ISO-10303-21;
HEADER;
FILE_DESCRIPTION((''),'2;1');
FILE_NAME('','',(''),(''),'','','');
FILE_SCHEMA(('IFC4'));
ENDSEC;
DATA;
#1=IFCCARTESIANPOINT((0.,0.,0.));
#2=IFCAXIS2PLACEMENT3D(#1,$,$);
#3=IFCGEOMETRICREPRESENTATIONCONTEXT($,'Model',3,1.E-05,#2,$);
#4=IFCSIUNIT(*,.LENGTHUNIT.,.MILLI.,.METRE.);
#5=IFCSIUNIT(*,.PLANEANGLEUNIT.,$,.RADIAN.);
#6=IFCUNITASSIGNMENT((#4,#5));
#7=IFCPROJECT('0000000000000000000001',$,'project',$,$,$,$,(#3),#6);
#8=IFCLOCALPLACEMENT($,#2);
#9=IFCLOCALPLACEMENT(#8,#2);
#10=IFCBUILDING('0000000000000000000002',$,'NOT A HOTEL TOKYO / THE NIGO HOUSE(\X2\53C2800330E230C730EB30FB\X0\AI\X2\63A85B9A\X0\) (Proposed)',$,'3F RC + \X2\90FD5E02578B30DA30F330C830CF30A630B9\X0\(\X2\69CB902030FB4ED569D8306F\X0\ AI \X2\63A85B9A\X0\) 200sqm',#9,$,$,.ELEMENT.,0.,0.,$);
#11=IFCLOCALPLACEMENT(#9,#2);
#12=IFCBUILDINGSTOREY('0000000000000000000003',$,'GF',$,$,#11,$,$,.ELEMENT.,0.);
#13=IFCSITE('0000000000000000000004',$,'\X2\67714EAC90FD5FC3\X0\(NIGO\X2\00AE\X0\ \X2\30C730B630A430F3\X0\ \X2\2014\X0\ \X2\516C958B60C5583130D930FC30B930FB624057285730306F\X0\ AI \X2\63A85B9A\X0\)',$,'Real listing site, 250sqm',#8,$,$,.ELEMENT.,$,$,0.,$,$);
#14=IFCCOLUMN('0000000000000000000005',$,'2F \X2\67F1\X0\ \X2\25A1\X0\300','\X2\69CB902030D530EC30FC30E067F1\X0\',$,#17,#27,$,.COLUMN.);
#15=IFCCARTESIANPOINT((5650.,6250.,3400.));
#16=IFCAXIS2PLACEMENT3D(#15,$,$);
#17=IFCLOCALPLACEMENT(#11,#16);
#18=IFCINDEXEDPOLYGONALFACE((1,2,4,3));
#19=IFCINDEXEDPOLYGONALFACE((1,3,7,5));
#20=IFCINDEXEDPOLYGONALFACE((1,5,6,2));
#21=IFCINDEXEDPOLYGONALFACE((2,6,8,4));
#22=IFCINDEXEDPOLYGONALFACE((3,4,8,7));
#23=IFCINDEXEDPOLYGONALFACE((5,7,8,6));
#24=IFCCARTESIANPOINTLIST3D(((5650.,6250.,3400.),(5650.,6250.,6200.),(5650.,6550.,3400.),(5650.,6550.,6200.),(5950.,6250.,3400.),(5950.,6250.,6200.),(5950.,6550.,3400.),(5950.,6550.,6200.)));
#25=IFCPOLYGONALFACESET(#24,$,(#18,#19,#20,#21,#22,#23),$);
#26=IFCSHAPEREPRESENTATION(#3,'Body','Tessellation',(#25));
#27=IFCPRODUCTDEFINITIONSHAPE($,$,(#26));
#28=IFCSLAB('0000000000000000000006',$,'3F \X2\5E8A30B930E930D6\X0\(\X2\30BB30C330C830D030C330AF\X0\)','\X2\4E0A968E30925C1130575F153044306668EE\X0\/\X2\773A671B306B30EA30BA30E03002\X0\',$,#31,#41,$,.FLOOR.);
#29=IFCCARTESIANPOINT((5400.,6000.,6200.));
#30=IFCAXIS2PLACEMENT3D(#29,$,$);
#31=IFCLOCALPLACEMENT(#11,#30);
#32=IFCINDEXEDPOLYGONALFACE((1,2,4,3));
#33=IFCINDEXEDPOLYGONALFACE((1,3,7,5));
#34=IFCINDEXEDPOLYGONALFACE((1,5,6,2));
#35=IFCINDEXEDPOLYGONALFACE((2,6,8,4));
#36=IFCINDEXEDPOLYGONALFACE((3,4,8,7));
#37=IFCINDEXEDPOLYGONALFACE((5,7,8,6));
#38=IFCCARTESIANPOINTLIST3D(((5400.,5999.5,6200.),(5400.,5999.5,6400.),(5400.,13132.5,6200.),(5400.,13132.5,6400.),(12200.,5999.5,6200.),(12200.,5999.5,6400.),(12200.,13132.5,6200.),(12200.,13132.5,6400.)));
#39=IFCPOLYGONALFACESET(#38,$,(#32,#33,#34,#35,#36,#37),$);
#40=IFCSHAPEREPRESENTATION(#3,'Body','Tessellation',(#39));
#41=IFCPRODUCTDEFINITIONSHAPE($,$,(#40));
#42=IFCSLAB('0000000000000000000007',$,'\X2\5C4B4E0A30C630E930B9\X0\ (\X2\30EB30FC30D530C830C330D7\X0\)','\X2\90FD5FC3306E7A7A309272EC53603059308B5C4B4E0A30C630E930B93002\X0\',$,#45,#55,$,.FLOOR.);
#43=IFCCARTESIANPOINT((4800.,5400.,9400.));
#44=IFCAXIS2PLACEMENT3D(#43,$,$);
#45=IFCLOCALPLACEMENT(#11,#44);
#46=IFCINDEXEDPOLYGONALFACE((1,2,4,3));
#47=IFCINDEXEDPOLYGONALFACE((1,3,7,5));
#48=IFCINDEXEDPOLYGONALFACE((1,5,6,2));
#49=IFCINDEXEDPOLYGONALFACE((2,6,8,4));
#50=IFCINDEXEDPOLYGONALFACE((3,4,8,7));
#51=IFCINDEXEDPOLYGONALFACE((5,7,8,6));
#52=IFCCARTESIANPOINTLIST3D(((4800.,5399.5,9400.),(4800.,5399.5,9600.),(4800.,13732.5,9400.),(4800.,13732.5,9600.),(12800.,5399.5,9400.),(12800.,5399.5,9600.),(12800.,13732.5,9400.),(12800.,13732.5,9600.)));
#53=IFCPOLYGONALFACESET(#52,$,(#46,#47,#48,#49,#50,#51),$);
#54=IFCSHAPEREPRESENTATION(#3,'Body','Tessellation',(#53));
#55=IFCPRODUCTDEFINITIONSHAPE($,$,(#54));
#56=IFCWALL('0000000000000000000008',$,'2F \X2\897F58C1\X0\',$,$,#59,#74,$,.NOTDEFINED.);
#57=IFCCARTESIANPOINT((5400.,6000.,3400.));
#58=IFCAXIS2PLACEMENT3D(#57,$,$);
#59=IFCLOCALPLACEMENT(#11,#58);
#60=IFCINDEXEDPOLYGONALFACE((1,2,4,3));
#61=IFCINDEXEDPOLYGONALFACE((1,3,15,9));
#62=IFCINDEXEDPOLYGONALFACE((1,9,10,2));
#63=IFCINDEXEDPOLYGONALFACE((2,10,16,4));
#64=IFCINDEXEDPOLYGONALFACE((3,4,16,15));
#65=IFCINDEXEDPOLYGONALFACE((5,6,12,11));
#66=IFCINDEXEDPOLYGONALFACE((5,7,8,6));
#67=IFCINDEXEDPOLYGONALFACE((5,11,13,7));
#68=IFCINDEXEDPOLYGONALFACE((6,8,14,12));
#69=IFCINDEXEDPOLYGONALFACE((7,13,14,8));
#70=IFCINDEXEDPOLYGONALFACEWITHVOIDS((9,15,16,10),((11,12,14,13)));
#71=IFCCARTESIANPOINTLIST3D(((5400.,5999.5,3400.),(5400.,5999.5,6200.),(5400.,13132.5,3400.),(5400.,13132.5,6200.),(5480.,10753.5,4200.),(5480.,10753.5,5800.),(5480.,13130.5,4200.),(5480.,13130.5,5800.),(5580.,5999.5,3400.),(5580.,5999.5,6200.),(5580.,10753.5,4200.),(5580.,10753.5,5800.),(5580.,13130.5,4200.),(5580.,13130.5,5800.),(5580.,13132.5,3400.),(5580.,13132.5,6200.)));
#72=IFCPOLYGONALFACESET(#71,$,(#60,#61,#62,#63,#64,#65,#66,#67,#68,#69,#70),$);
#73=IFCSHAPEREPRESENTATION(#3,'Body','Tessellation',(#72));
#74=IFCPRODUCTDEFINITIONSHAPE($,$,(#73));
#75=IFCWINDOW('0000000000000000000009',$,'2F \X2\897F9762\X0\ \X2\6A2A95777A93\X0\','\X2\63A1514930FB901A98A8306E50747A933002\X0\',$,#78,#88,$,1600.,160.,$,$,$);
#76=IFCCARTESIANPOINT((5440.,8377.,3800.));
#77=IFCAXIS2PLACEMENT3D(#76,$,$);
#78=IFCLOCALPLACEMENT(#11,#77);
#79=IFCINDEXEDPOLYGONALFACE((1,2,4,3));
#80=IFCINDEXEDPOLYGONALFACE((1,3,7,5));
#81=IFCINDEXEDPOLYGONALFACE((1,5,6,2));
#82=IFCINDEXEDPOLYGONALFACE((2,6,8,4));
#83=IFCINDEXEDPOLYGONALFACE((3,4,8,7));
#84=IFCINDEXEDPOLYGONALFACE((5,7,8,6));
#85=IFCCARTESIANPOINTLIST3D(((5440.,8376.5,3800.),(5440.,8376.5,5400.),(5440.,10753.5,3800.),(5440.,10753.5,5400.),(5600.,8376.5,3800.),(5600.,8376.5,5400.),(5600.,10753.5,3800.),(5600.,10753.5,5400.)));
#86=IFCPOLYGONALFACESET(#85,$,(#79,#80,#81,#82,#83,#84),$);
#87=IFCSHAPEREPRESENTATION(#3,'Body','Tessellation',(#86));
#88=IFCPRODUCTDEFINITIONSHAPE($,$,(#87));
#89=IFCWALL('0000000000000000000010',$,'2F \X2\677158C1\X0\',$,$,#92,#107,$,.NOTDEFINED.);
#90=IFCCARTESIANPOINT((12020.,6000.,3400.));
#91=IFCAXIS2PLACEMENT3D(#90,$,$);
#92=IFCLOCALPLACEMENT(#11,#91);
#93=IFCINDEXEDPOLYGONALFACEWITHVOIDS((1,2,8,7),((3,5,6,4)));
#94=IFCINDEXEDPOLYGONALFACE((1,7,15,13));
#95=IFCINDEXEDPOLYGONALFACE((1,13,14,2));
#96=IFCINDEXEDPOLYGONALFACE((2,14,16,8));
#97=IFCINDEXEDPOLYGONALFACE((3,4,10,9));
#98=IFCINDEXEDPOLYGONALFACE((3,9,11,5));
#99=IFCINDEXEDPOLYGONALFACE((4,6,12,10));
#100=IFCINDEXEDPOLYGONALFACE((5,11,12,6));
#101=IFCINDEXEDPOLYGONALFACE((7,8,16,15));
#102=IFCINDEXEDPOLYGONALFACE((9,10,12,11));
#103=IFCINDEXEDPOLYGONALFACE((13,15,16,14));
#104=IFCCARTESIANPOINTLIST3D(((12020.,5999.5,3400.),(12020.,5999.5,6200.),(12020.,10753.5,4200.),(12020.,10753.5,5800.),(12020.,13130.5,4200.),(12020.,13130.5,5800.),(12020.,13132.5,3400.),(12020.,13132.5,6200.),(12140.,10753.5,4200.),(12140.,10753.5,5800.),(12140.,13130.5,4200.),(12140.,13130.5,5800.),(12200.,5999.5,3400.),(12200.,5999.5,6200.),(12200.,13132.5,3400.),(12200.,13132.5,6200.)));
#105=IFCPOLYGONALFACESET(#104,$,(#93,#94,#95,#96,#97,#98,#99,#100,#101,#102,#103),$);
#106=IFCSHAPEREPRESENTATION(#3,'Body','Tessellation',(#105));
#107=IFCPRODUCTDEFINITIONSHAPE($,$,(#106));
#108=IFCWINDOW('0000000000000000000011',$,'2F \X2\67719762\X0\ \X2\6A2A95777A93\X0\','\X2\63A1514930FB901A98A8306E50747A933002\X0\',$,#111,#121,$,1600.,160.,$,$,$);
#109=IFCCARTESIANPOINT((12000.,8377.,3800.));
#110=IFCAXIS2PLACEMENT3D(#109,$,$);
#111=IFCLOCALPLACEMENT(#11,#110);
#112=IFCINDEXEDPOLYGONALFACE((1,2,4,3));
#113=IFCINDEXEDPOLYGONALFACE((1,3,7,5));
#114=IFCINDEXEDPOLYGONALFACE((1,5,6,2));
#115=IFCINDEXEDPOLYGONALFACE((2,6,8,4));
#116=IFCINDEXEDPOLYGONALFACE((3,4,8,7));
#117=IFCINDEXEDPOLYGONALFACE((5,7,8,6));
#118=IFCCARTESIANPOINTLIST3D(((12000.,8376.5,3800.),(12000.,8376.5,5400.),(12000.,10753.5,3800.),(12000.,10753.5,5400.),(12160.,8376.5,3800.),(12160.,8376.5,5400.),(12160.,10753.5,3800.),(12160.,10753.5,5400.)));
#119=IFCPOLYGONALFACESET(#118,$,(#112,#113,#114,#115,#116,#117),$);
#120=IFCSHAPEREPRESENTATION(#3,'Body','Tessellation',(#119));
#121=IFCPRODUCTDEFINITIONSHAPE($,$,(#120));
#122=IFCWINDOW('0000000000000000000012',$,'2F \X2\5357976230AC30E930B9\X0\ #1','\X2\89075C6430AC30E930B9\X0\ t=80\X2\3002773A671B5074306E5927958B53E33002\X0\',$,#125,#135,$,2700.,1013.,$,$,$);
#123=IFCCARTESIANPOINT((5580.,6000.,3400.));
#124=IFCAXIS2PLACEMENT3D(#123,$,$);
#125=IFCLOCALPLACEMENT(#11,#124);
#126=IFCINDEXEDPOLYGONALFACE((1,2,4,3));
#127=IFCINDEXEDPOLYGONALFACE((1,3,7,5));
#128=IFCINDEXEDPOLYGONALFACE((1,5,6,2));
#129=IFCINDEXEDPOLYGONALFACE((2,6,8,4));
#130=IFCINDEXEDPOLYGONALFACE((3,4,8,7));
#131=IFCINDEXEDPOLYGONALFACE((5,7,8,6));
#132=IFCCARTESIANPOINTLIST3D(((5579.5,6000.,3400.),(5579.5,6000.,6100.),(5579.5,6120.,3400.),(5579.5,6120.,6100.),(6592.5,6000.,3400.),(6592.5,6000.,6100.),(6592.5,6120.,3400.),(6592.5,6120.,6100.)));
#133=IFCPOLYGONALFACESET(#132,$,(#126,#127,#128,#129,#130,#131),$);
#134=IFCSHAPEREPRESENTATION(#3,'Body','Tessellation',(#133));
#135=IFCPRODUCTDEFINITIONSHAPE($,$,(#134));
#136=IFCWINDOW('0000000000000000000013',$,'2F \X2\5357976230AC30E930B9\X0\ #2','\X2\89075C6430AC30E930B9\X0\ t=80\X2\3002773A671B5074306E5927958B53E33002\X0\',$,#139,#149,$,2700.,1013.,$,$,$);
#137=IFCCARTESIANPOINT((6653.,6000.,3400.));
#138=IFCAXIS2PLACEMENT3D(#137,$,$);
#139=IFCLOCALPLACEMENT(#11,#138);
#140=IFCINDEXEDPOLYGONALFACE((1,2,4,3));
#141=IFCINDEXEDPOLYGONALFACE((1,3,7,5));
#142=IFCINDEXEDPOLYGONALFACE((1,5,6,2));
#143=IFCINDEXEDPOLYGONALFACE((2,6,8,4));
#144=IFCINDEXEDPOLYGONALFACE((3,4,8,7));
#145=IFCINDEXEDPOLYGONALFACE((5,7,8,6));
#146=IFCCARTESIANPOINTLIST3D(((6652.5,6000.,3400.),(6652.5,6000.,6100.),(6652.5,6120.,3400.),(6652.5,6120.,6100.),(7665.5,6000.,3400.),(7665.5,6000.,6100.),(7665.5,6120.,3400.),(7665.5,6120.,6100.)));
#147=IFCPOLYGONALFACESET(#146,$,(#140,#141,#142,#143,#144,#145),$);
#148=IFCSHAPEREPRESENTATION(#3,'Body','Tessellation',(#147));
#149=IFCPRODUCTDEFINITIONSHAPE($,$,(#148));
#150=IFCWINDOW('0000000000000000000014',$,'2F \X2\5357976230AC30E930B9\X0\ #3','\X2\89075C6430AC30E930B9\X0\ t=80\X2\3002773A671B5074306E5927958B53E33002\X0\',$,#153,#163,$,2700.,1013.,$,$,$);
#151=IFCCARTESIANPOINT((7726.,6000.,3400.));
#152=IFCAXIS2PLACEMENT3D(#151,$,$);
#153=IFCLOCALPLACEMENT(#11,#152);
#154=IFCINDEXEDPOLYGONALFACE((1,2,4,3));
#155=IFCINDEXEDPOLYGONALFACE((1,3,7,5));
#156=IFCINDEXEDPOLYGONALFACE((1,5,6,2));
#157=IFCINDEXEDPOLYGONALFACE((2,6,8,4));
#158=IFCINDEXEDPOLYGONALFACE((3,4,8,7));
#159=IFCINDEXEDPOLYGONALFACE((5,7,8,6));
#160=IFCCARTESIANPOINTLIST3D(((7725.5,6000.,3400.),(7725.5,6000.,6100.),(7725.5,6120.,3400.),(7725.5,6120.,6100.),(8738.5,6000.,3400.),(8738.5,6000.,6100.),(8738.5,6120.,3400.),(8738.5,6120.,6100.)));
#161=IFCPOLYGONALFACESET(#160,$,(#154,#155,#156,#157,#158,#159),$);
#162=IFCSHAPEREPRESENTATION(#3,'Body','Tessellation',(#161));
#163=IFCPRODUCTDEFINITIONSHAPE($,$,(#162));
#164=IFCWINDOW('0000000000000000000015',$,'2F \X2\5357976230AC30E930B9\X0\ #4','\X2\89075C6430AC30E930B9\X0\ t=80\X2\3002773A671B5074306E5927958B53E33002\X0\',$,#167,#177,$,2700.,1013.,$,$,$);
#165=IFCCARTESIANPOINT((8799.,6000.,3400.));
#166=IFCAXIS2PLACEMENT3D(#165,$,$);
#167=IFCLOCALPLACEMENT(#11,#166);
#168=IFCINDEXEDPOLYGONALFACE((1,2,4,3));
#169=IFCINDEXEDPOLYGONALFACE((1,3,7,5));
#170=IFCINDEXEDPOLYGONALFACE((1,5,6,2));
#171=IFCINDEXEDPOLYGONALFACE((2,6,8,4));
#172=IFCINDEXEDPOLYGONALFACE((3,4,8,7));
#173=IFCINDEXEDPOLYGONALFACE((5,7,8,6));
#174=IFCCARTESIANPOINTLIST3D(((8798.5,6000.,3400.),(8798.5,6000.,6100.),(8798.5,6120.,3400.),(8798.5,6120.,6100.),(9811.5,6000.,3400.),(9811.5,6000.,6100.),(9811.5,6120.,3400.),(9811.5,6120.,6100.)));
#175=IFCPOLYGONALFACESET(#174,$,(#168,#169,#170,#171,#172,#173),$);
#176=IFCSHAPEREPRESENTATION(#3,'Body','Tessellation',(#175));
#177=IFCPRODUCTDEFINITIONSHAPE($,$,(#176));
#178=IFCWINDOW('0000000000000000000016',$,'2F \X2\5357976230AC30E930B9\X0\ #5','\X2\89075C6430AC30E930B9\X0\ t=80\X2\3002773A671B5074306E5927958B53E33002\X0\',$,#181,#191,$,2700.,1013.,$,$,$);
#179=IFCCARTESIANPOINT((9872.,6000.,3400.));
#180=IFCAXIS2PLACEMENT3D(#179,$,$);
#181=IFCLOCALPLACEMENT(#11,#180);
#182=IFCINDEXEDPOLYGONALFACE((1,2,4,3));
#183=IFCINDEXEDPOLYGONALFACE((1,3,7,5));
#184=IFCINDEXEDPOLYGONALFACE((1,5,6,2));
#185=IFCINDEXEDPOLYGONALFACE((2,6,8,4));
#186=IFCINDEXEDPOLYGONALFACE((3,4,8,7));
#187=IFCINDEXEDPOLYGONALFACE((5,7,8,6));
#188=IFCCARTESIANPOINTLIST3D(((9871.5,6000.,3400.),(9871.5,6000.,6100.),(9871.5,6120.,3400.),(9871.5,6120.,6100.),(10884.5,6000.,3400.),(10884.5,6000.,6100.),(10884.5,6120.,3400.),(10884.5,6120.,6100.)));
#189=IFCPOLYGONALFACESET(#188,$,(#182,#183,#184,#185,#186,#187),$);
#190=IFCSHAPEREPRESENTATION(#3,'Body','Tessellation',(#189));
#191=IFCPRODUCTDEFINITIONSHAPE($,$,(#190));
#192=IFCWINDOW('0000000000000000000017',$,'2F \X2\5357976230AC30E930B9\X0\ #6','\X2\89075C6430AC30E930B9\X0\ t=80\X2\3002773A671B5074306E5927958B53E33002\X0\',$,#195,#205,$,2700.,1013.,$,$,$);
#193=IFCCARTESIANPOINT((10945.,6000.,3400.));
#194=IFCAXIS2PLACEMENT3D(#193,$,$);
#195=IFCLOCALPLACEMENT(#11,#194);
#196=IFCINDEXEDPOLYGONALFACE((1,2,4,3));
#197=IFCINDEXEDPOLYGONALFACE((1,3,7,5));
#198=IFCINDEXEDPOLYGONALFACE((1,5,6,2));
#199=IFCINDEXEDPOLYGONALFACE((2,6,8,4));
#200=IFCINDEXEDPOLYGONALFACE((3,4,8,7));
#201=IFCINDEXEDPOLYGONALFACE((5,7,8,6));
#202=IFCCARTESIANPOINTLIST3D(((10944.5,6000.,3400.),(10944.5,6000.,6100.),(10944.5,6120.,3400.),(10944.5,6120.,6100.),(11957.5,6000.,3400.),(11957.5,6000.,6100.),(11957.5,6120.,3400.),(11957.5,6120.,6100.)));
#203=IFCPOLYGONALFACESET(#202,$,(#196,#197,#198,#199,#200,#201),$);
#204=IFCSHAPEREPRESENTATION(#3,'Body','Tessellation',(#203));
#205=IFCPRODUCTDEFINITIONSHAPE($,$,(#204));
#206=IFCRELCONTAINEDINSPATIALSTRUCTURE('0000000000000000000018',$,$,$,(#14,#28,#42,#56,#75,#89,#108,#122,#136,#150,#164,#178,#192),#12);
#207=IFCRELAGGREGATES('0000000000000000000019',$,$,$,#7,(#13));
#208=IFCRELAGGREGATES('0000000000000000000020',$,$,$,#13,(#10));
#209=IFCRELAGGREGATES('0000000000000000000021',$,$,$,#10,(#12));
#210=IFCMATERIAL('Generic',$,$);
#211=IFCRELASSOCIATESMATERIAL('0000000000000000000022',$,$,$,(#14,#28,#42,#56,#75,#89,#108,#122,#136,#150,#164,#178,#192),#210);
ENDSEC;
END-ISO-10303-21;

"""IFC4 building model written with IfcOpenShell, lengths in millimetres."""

from ifc_helpers import new_model, si_unit, frame, frame_2d, origin, place, context, project, spatial, rectangle, extrude, material, element, fill, save


model = new_model("IFC4")

# Units and contexts
model_context = context("Model", 3, precision=1e-05, world=origin())
ifc_project = project(units=[si_unit("LENGTHUNIT", "METRE", prefix="MILLI"), si_unit("PLANEANGLEUNIT", "RADIAN")], contexts=[model_context])

# Site, building, storey
site_placement = place(None, origin())
site = spatial("IfcSite", under=ifc_project, at=site_placement, Name="東京都心(NIGO® デザイン — 公開情報ベース・所在地は AI 推定)", ObjectType="Real listing site, 250sqm", CompositionType="ELEMENT", RefElevation=0.0)
building_placement = place(site_placement, origin())
building = spatial("IfcBuilding", under=site, at=building_placement, Name="NOT A HOTEL TOKYO / THE NIGO HOUSE(参考モデル・AI推定) (Proposed)", ObjectType="3F RC + 都市型ペントハウス(構造・仕様は AI 推定) 200sqm", CompositionType="ELEMENT", ElevationOfRefHeight=0.0, ElevationOfTerrain=0.0)
storey_placement = place(building_placement, origin())
storey = spatial("IfcBuildingStorey", under=building, at=storey_placement, Name="GF", CompositionType="ELEMENT", Elevation=0.0)

# Column
ifc_material_1 = material(Name="Generic")
column_placement = place(storey_placement, frame((5650.0, 6250.0, 3400.0)))
element("IfcColumn", 1, at=column_placement, inside=storey, material=ifc_material_1, Name="2F 柱 □300", Description="構造フレーム柱", PredefinedType="COLUMN", context=model_context, shape_type="SweptSolid", body=[
    extrude(rectangle(XDim=300.0, YDim=300.0, at=frame_2d((150.0, 150.0))), frame((5650.0, 6250.0, 3400.0)), (0.0, 0.0, 1.0), 2800.0),
])

# Slabs
slab_1_placement = place(storey_placement, frame((5400.0, 6000.0, 6200.0)))
element("IfcSlab", 2, at=slab_1_placement, inside=storey, material=ifc_material_1, Name="3F 床スラブ(セットバック)", Description="上階を少し引いて森/眺望にリズム。", PredefinedType="FLOOR", context=model_context, shape_type="SweptSolid", body=[
    extrude(rectangle(XDim=6800.0, YDim=7133.0, at=frame_2d((3400.0, 3566.0))), frame((5400.0, 6000.0, 6200.0)), (0.0, 0.0, 1.0), 200.0),
])
slab_2_placement = place(storey_placement, frame((4800.0, 5400.0, 9400.0)))
element("IfcSlab", 3, at=slab_2_placement, inside=storey, material=ifc_material_1, Name="屋上テラス (ルーフトップ)", Description="都心の空を独占する屋上テラス。", PredefinedType="FLOOR", context=model_context, shape_type="SweptSolid", body=[
    extrude(rectangle(XDim=8000.0, YDim=8333.0, at=frame_2d((4000.0, 4166.0))), frame((4800.0, 5400.0, 9400.0)), (0.0, 0.0, 1.0), 200.0),
])

# Walls, openings, windows
wall_1_placement = place(storey_placement, frame((5400.0, 6000.0, 3400.0)))
wall_1 = element("IfcWall", 4, at=wall_1_placement, inside=storey, material=ifc_material_1, Name="2F 西壁", PredefinedType="NOTDEFINED", context=model_context, shape_type="SweptSolid", body=[
    extrude(rectangle(XDim=180.0, YDim=7133.0, at=frame_2d((90.0, 3566.0))), frame((5400.0, 6000.0, 3400.0)), (0.0, 0.0, 1.0), 2800.0),
])
opening_1_placement = place(storey_placement, frame((5440.0, 8377.0, 3800.0)))
opening_1 = element("IfcOpeningElement", 5, at=opening_1_placement, cuts=wall_1, PredefinedType="NOTDEFINED", context=model_context, shape_type="SweptSolid", body=[
    extrude(rectangle(XDim=160.0, YDim=2377.0, at=frame_2d((80.0, 1188.0))), frame((5440.0, 8377.0, 3800.0)), (0.0, 0.0, 1.0), 1600.0),
])
window_1_placement = place(storey_placement, frame((5440.0, 8377.0, 3800.0)))
window_1 = element("IfcWindow", 6, at=window_1_placement, inside=storey, material=ifc_material_1, Name="2F 西面 横長窓", Description="採光・通風の側窓。", OverallHeight=1600.0, OverallWidth=160.0, context=model_context, shape_type="SweptSolid", body=[
    extrude(rectangle(XDim=160.0, YDim=2377.0, at=frame_2d((80.0, 1188.0))), frame((5440.0, 8377.0, 3800.0)), (0.0, 0.0, 1.0), 1600.0),
])
fill(opening_1, window_1)
wall_2_placement = place(storey_placement, frame((12020.0, 6000.0, 3400.0)))
wall_2 = element("IfcWall", 7, at=wall_2_placement, inside=storey, material=ifc_material_1, Name="2F 東壁", PredefinedType="NOTDEFINED", context=model_context, shape_type="SweptSolid", body=[
    extrude(rectangle(XDim=180.0, YDim=7133.0, at=frame_2d((90.0, 3566.0))), frame((12020.0, 6000.0, 3400.0)), (0.0, 0.0, 1.0), 2800.0),
])
opening_2_placement = place(storey_placement, frame((12000.0, 8377.0, 3800.0)))
opening_2 = element("IfcOpeningElement", 8, at=opening_2_placement, cuts=wall_2, PredefinedType="NOTDEFINED", context=model_context, shape_type="SweptSolid", body=[
    extrude(rectangle(XDim=160.0, YDim=2377.0, at=frame_2d((80.0, 1188.0))), frame((12000.0, 8377.0, 3800.0)), (0.0, 0.0, 1.0), 1600.0),
])
window_2_placement = place(storey_placement, frame((12000.0, 8377.0, 3800.0)))
window_2 = element("IfcWindow", 9, at=window_2_placement, inside=storey, material=ifc_material_1, Name="2F 東面 横長窓", Description="採光・通風の側窓。", OverallHeight=1600.0, OverallWidth=160.0, context=model_context, shape_type="SweptSolid", body=[
    extrude(rectangle(XDim=160.0, YDim=2377.0, at=frame_2d((80.0, 1188.0))), frame((12000.0, 8377.0, 3800.0)), (0.0, 0.0, 1.0), 1600.0),
])
fill(opening_2, window_2)

# Windows
window_3_placement = place(storey_placement, frame((5580.0, 6000.0, 3400.0)))
element("IfcWindow", 10, at=window_3_placement, inside=storey, material=ifc_material_1, Name="2F 南面ガラス #1", Description="複層ガラス t=80。眺望側の大開口。", OverallHeight=2700.0, OverallWidth=1013.0, context=model_context, shape_type="SweptSolid", body=[
    extrude(rectangle(XDim=1013.0, YDim=120.0, at=frame_2d((506.0, 60.0))), frame((5580.0, 6000.0, 3400.0)), (0.0, 0.0, 1.0), 2700.0),
])
window_4_placement = place(storey_placement, frame((6653.0, 6000.0, 3400.0)))
element("IfcWindow", 11, at=window_4_placement, inside=storey, material=ifc_material_1, Name="2F 南面ガラス #2", Description="複層ガラス t=80。眺望側の大開口。", OverallHeight=2700.0, OverallWidth=1013.0, context=model_context, shape_type="SweptSolid", body=[
    extrude(rectangle(XDim=1013.0, YDim=120.0, at=frame_2d((506.0, 60.0))), frame((6653.0, 6000.0, 3400.0)), (0.0, 0.0, 1.0), 2700.0),
])
window_5_placement = place(storey_placement, frame((7726.0, 6000.0, 3400.0)))
element("IfcWindow", 12, at=window_5_placement, inside=storey, material=ifc_material_1, Name="2F 南面ガラス #3", Description="複層ガラス t=80。眺望側の大開口。", OverallHeight=2700.0, OverallWidth=1013.0, context=model_context, shape_type="SweptSolid", body=[
    extrude(rectangle(XDim=1013.0, YDim=120.0, at=frame_2d((506.0, 60.0))), frame((7726.0, 6000.0, 3400.0)), (0.0, 0.0, 1.0), 2700.0),
])
window_6_placement = place(storey_placement, frame((8799.0, 6000.0, 3400.0)))
element("IfcWindow", 13, at=window_6_placement, inside=storey, material=ifc_material_1, Name="2F 南面ガラス #4", Description="複層ガラス t=80。眺望側の大開口。", OverallHeight=2700.0, OverallWidth=1013.0, context=model_context, shape_type="SweptSolid", body=[
    extrude(rectangle(XDim=1013.0, YDim=120.0, at=frame_2d((506.0, 60.0))), frame((8799.0, 6000.0, 3400.0)), (0.0, 0.0, 1.0), 2700.0),
])
window_7_placement = place(storey_placement, frame((9872.0, 6000.0, 3400.0)))
element("IfcWindow", 14, at=window_7_placement, inside=storey, material=ifc_material_1, Name="2F 南面ガラス #5", Description="複層ガラス t=80。眺望側の大開口。", OverallHeight=2700.0, OverallWidth=1013.0, context=model_context, shape_type="SweptSolid", body=[
    extrude(rectangle(XDim=1013.0, YDim=120.0, at=frame_2d((506.0, 60.0))), frame((9872.0, 6000.0, 3400.0)), (0.0, 0.0, 1.0), 2700.0),
])
window_8_placement = place(storey_placement, frame((10945.0, 6000.0, 3400.0)))
element("IfcWindow", 15, at=window_8_placement, inside=storey, material=ifc_material_1, Name="2F 南面ガラス #6", Description="複層ガラス t=80。眺望側の大開口。", OverallHeight=2700.0, OverallWidth=1013.0, context=model_context, shape_type="SweptSolid", body=[
    extrude(rectangle(XDim=1013.0, YDim=120.0, at=frame_2d((506.0, 60.0))), frame((10945.0, 6000.0, 3400.0)), (0.0, 0.0, 1.0), 2700.0),
])

save(model, "model.ifc")
